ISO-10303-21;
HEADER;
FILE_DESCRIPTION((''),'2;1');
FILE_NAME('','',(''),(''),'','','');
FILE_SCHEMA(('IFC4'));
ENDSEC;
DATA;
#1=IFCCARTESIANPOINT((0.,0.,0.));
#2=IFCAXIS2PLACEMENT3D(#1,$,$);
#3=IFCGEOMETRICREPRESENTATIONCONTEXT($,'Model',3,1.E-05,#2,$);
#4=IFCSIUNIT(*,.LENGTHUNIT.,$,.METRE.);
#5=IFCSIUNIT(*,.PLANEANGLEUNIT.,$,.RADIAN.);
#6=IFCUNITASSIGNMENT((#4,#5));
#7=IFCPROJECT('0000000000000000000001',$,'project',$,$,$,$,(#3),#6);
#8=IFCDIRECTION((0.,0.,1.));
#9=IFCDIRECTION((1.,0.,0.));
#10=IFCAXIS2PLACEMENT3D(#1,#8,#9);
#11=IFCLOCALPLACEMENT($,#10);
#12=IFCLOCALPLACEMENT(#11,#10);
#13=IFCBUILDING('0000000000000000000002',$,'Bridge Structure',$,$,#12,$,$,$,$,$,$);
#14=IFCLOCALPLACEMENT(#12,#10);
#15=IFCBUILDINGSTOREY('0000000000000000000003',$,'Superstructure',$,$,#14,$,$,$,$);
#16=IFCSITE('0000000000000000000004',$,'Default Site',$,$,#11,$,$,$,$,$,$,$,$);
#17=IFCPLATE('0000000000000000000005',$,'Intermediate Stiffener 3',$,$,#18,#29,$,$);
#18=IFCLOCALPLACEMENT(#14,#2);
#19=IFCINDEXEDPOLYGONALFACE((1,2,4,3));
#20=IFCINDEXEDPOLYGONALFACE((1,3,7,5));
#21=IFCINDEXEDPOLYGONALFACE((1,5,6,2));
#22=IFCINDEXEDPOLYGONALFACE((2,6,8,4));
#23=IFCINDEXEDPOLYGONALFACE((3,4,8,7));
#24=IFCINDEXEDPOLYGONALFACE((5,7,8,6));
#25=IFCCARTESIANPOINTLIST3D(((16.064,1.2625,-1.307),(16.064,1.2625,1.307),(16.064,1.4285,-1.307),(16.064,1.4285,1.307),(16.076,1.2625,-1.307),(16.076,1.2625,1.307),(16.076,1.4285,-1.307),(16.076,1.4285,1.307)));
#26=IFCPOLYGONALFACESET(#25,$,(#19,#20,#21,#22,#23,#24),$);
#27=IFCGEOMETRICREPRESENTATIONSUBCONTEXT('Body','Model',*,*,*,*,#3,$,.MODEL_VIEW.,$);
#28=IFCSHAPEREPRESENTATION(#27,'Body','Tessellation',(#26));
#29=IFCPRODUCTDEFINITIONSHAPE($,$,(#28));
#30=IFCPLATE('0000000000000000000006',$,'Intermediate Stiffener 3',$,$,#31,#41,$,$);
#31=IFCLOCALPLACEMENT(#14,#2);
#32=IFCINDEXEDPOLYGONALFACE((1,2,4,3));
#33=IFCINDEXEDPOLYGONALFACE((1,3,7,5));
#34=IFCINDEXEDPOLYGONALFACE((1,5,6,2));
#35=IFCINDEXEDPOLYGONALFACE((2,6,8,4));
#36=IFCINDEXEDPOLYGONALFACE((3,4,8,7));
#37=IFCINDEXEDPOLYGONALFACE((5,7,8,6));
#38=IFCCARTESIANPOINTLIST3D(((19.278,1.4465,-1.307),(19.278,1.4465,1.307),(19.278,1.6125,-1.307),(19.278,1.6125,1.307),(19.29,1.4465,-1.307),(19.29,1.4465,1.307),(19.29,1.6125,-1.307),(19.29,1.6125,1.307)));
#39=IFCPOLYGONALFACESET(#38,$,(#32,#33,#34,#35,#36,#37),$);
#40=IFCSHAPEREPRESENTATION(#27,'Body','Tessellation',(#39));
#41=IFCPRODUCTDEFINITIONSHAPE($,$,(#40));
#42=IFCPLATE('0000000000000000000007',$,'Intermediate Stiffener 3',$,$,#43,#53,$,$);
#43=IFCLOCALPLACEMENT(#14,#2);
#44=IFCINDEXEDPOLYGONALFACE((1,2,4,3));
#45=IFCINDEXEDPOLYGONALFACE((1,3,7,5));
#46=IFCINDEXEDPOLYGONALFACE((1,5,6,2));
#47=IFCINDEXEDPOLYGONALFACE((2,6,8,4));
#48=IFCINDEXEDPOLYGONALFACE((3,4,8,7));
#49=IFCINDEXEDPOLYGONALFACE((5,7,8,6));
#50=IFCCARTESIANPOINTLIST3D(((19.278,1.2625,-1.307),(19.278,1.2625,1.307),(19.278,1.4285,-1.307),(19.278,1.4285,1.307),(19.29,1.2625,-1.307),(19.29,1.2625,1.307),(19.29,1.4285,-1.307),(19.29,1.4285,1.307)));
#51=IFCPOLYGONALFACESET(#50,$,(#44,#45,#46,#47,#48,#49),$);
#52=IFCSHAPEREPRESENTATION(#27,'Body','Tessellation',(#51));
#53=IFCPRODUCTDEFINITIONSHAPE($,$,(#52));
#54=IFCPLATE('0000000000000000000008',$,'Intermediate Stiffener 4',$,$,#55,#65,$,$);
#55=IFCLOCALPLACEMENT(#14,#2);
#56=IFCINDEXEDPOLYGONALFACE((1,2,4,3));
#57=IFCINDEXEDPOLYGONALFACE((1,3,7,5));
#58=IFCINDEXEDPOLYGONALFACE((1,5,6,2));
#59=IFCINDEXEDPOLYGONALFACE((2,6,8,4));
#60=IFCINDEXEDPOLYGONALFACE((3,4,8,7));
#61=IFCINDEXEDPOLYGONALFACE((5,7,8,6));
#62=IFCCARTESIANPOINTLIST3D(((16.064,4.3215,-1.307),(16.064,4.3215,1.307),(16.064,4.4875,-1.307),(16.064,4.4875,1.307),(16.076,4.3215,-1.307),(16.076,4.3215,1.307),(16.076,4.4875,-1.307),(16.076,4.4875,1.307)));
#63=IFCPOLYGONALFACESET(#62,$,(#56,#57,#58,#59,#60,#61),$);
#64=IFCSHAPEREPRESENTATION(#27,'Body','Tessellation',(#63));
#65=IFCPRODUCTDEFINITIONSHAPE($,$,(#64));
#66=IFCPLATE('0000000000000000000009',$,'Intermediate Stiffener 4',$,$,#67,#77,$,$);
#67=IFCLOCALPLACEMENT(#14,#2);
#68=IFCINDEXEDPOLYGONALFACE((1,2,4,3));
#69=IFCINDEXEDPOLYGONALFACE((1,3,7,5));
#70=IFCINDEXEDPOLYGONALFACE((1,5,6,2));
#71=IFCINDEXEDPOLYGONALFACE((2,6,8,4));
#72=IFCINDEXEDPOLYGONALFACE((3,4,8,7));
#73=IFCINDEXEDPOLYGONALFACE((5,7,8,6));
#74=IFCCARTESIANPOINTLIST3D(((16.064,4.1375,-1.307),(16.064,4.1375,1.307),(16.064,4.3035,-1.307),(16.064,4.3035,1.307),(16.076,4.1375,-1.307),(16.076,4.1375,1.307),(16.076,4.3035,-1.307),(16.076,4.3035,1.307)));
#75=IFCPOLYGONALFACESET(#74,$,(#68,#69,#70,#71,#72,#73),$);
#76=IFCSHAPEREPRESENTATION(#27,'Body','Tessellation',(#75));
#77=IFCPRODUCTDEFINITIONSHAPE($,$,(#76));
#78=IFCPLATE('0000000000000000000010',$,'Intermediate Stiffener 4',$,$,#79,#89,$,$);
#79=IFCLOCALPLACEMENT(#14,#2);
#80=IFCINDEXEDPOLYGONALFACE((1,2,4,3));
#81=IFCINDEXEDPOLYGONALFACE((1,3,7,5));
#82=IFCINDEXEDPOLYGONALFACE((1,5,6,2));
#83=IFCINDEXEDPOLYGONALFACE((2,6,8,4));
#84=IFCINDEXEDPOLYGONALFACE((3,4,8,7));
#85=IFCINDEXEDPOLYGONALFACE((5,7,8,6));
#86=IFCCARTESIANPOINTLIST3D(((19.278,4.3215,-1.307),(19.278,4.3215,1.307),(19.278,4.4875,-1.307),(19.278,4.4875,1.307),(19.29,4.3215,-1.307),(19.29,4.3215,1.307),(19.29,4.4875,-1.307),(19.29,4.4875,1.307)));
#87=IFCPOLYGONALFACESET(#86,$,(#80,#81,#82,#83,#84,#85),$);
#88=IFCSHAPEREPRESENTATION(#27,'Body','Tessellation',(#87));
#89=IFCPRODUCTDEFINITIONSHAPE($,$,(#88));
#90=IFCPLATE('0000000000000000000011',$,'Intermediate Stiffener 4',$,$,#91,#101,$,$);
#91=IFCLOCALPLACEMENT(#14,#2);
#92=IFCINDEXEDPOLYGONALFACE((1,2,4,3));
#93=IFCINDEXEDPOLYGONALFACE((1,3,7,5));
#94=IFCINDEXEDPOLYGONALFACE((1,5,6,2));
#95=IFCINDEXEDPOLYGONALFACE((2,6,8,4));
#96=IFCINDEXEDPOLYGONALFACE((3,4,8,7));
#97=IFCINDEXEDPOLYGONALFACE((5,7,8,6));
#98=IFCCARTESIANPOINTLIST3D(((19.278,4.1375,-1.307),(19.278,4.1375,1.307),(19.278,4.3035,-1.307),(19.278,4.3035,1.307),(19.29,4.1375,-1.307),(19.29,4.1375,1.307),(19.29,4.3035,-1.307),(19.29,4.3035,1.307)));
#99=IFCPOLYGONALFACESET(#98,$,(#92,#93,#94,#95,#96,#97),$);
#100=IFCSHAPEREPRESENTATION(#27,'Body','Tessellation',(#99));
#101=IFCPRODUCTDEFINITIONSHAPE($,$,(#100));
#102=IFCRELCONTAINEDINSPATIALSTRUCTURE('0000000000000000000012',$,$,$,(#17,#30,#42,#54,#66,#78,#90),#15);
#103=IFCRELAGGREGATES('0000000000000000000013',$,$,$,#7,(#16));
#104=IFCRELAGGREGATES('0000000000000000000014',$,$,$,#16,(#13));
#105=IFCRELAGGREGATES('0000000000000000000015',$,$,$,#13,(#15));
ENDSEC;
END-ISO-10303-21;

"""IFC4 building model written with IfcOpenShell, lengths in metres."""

from ifc_helpers import new_model, si_unit, frame, origin, origin_with_axes, origin_2d_with_axis, place, context, subcontext, project, spatial, rectangle, extrude, element, save


model = new_model("IFC4")

# Units and contexts
model_context = context("Model", 3, precision=1e-05, world=origin())
body_context = subcontext(model_context, "Body", "Model", "MODEL_VIEW")
ifc_project = project(units=[si_unit("LENGTHUNIT", "METRE"), si_unit("PLANEANGLEUNIT", "RADIAN")], contexts=[model_context])

# Site, building, storey
site_placement = place(None, origin_with_axes())
site = spatial("IfcSite", under=ifc_project, at=site_placement, Name="Default Site")
building_placement = place(site_placement, origin_with_axes())
building = spatial("IfcBuilding", under=site, at=building_placement, Name="Bridge Structure")
storey_placement = place(building_placement, origin_with_axes())
storey = spatial("IfcBuildingStorey", under=building, at=storey_placement, Name="Superstructure")

# Plates
for number, where, z_axis, x_axis, name in (
    (1, (16.07, 1.3455, -1.307), (0.0, 0.0, 1.0), (1.0, 0.0, 0.0), "Intermediate Stiffener 3"),
    (2, (19.284, 1.5295, -1.307), (0.0, 0.0, 1.0), (1.0, 0.0, 0.0), "Intermediate Stiffener 3"),
    (3, (19.284, 1.3455, -1.307), (0.0, 0.0, 1.0), (1.0, 0.0, 0.0), "Intermediate Stiffener 3"),
    (4, (16.07, 4.4045, -1.307), (0.0, 0.0, 1.0), (1.0, 0.0, 0.0), "Intermediate Stiffener 4"),
    (5, (16.07, 4.2205, -1.307), (0.0, 0.0, 1.0), (1.0, 0.0, 0.0), "Intermediate Stiffener 4"),
    (6, (19.284, 4.4045, -1.307), (0.0, 0.0, 1.0), (1.0, 0.0, 0.0), "Intermediate Stiffener 4"),
    (7, (19.284, 4.2205, -1.307), (0.0, 0.0, 1.0), (1.0, 0.0, 0.0), "Intermediate Stiffener 4"),
):
    element("IfcPlate", number, at=place(storey_placement, frame(where, z_axis=z_axis, x_axis=x_axis)), inside=storey, Name=name, context=body_context, shape_type="SweptSolid", body=[
        extrude(rectangle(XDim=0.012, YDim=0.166, at=origin_2d_with_axis()), origin_with_axes(), (0.0, 0.0, 1.0), 2.614),
    ])

save(model, "model.ifc")
